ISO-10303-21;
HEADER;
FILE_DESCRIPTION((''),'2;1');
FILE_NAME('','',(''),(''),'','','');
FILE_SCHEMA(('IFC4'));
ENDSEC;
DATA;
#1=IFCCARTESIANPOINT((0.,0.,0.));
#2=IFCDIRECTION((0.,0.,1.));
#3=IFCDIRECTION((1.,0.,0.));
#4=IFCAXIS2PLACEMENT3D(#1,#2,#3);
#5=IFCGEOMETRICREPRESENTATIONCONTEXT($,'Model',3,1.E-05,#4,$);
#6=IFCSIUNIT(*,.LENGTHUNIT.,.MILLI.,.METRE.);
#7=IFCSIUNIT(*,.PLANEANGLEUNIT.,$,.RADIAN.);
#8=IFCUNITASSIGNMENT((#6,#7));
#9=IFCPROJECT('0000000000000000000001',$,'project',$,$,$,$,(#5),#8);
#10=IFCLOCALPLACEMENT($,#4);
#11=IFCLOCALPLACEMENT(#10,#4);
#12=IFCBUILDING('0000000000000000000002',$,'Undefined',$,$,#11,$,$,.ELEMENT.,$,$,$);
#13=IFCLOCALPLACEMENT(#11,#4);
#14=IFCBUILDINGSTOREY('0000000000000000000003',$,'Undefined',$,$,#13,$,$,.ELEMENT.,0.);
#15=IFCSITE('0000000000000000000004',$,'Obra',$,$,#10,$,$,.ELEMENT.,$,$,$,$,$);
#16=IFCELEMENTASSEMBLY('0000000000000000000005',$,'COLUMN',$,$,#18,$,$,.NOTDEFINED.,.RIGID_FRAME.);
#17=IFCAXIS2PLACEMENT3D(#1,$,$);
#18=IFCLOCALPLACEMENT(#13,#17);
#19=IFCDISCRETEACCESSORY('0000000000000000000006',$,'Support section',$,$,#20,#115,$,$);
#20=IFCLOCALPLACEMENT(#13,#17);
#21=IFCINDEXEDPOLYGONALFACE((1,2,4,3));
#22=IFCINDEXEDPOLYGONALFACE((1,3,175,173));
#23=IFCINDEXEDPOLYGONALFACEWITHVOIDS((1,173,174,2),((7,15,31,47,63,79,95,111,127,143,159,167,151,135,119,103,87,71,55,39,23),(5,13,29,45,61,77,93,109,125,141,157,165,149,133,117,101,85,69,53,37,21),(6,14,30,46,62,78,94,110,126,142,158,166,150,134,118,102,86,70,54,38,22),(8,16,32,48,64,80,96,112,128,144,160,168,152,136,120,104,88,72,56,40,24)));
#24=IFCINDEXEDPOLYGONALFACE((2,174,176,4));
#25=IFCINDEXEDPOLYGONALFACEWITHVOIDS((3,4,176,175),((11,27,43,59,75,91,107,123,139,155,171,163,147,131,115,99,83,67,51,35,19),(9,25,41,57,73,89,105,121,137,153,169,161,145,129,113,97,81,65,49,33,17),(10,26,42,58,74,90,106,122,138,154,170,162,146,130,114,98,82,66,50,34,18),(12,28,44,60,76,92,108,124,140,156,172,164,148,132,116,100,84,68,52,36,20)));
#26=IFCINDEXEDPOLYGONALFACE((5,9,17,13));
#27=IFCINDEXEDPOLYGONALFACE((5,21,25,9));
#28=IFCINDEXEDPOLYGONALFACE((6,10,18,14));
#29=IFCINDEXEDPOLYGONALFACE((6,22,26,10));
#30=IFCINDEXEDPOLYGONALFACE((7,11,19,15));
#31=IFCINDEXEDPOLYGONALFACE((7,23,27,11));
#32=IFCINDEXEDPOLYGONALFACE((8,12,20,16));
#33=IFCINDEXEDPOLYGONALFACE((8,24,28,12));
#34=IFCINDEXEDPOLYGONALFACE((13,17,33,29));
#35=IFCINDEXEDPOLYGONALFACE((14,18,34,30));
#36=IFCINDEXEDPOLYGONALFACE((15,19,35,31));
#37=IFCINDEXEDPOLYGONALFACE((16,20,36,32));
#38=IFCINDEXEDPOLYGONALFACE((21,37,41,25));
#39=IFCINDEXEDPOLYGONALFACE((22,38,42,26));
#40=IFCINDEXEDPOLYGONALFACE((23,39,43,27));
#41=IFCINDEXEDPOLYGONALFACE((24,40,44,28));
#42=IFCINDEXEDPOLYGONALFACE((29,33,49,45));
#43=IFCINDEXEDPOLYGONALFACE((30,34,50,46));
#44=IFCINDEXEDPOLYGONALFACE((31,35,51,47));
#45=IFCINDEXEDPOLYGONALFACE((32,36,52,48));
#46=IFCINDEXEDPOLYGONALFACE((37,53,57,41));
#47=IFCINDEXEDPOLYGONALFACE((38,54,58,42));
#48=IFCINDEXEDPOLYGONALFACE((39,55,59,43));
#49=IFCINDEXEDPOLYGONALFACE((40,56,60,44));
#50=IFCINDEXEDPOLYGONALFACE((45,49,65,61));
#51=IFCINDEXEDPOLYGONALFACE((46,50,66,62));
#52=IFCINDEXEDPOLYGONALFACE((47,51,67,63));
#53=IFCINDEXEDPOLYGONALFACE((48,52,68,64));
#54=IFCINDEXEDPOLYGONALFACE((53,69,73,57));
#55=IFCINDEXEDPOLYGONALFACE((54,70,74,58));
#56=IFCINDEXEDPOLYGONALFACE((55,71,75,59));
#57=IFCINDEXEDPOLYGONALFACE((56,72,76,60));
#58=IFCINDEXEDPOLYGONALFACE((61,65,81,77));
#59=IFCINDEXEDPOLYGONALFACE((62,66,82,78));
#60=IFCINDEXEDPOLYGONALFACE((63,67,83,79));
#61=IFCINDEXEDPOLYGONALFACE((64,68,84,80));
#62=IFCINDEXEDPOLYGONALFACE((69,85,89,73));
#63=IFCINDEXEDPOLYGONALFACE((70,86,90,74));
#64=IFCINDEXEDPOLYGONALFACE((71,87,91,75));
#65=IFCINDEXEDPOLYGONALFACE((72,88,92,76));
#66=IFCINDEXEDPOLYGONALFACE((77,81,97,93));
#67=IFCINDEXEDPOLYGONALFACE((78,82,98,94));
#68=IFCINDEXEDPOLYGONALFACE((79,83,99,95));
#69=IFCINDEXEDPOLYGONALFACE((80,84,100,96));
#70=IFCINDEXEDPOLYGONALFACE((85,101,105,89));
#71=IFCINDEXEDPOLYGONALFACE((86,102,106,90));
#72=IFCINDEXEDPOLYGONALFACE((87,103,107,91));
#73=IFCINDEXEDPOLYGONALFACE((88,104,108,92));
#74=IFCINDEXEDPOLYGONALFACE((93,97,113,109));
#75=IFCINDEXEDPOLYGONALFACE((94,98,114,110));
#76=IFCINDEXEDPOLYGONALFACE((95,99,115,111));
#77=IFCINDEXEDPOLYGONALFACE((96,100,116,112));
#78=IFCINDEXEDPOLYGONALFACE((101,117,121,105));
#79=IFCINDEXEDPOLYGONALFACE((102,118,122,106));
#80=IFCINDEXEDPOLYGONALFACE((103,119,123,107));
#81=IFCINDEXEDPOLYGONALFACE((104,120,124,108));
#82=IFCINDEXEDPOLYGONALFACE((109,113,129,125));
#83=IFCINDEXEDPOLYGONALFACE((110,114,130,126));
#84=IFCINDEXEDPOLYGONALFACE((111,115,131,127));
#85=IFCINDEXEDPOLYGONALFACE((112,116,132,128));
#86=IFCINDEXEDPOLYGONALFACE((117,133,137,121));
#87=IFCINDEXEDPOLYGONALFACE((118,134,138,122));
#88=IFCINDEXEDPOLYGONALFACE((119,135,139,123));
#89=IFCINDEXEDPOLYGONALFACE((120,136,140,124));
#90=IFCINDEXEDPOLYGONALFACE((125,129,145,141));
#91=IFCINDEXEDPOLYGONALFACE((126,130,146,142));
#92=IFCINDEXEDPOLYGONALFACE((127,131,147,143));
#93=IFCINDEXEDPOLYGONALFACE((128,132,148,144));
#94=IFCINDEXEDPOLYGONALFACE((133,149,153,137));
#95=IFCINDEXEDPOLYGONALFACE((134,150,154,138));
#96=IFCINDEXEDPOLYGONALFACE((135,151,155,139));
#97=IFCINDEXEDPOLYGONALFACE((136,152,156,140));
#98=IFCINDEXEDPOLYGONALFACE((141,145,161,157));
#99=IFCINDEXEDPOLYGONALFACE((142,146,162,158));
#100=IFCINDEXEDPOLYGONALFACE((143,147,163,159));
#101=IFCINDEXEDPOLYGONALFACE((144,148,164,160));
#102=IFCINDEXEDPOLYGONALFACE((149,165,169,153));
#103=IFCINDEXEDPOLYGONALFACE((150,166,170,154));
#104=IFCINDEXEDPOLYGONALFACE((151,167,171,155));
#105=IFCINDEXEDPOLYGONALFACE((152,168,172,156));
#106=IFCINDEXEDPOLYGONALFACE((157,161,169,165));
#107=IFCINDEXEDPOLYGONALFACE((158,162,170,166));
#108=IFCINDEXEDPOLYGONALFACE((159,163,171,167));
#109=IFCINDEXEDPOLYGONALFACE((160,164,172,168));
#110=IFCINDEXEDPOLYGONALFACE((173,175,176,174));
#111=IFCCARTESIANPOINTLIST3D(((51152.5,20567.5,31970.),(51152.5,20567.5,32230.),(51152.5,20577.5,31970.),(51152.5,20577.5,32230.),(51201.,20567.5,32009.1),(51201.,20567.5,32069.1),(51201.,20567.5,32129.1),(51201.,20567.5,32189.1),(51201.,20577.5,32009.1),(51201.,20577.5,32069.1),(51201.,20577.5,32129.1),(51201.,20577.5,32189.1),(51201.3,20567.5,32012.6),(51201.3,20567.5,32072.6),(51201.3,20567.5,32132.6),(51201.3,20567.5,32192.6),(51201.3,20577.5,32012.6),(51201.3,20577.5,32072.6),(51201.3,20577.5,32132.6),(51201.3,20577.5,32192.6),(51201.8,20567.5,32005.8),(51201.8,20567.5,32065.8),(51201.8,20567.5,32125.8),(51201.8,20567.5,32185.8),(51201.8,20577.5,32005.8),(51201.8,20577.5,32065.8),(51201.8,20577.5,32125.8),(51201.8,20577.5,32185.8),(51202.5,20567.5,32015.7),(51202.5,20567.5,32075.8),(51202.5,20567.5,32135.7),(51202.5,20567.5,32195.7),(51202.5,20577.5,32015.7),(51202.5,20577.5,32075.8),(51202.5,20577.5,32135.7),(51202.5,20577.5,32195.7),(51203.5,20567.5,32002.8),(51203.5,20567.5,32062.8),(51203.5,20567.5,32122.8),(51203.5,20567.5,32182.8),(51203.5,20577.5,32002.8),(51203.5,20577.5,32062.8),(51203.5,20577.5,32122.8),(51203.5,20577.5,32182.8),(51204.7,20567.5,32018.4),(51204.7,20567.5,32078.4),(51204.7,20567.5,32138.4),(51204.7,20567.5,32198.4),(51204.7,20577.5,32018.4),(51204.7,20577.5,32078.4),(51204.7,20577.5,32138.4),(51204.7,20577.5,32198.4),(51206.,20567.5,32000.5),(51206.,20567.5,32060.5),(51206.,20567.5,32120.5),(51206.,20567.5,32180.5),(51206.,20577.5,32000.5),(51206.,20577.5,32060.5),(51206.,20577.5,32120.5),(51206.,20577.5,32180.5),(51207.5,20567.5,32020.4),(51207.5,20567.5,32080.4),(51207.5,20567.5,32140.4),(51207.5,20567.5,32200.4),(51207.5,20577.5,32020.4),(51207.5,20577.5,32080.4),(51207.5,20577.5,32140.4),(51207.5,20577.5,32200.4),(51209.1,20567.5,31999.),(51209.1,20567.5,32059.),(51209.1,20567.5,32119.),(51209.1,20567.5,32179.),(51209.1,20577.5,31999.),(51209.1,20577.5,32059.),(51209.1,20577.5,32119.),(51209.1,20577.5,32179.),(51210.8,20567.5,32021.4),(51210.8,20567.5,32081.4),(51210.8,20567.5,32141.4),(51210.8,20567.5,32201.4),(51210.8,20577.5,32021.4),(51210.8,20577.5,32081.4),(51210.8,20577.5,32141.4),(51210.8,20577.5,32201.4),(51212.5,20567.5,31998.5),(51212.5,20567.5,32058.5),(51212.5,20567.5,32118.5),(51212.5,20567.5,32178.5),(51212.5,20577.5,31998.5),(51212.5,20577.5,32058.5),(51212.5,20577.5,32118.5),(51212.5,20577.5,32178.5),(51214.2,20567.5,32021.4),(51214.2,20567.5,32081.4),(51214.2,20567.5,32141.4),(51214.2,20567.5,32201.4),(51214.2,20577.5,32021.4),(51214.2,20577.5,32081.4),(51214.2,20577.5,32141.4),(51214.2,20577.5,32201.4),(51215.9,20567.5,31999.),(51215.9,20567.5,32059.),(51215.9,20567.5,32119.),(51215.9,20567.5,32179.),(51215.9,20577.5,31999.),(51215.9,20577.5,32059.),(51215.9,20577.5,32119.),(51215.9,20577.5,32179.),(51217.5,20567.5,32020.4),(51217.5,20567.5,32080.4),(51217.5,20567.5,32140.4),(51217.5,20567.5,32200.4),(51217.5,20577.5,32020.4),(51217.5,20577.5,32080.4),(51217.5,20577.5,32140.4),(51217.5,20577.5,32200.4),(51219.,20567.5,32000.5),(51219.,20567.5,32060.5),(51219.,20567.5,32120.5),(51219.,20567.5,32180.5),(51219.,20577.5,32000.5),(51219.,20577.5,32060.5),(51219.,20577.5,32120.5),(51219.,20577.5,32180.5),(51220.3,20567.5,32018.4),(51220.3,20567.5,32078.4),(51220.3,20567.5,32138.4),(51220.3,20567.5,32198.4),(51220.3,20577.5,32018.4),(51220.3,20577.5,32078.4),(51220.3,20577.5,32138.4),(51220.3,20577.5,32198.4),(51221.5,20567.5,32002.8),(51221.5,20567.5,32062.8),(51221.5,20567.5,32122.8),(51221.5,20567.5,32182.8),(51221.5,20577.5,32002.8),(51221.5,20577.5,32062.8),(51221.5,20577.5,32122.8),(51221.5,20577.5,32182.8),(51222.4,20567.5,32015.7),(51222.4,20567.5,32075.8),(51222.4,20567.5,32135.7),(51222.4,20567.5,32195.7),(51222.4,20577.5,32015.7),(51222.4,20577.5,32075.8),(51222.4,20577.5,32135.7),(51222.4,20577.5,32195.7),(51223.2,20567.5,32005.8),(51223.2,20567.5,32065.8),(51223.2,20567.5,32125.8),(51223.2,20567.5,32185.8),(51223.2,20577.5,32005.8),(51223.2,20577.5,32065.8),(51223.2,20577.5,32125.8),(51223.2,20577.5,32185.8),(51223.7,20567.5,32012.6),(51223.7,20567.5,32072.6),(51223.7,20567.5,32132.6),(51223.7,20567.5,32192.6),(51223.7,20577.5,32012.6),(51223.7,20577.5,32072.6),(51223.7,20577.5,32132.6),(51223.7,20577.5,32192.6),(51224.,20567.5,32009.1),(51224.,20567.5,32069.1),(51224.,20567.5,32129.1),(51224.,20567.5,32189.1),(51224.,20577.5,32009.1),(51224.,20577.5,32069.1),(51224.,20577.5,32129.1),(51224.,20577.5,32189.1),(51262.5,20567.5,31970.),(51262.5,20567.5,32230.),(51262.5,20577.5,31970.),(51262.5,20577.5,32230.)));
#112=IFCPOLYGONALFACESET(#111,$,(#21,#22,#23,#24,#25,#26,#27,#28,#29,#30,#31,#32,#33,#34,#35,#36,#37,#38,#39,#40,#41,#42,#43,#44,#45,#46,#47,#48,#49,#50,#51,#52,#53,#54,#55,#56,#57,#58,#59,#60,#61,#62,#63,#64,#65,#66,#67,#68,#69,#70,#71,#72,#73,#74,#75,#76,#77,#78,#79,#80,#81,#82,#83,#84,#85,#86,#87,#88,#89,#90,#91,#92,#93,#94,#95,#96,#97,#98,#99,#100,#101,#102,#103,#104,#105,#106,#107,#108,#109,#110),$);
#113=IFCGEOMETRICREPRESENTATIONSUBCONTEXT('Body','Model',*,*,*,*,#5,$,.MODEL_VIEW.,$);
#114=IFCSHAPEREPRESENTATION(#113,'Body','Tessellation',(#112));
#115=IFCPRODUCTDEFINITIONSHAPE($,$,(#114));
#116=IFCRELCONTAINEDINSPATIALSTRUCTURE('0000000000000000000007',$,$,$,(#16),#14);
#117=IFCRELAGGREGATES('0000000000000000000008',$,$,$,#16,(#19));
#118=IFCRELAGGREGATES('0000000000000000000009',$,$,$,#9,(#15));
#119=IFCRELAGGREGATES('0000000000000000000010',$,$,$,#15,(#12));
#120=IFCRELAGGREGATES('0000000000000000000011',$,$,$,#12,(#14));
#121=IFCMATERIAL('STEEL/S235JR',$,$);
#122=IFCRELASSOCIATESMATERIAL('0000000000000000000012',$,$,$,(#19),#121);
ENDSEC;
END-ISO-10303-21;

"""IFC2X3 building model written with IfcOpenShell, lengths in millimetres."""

from ifc_helpers import new_model, si_unit, frame, origin_with_axes, origin_2d_with_axis, place, context, subcontext, project, spatial, rectangle, circle, extrude, source, transform, mapped, material, element, aggregate, save


model = new_model("IFC2X3")

# Units and contexts
model_context = context("Model", 3, precision=1e-05, world=origin_with_axes())
body_context = subcontext(model_context, "Body", "Model", "MODEL_VIEW")
ifc_project = project(units=[si_unit("LENGTHUNIT", "METRE", prefix="MILLI"), si_unit("PLANEANGLEUNIT", "RADIAN")], contexts=[model_context])

# Site, building, storey
site_placement = place(None, origin_with_axes())
site = spatial("IfcSite", under=ifc_project, at=site_placement, Name="Obra", CompositionType="ELEMENT")
building_placement = place(site_placement, origin_with_axes())
building = spatial("IfcBuilding", under=site, at=building_placement, Name="Undefined", CompositionType="ELEMENT")
storey_placement = place(building_placement, origin_with_axes())
storey = spatial("IfcBuildingStorey", under=building, at=storey_placement, Name="Undefined", CompositionType="ELEMENT", Elevation=0.0)

# Element assembly
ifc_material_1 = material(Name="STEEL/S235JR")
assembly_1_placement = place(storey_placement, origin_with_axes())
assembly_1 = element("IfcElementAssembly", 1, at=assembly_1_placement, inside=storey, Name="COLUMN", AssemblyPlace="NOTDEFINED", PredefinedType="RIGID_FRAME")

# Discrete accessory, opening
discrete_accessory_1_placement = place(assembly_1_placement, frame((51207.5, 20572.5, 31970.0), z_axis=(0.0, 0.0, 1.0), x_axis=(-1.0, 0.0, 0.0)))
discrete_accessory_1 = element("IfcDiscreteAccessory", 2, at=discrete_accessory_1_placement, material=ifc_material_1, Name="Support section", context=body_context, shape_type="SweptSolid", body=[
    extrude(rectangle(XDim=10.0, YDim=110.0, at=origin_2d_with_axis()), frame((0.0, 0.0, 260.0), z_axis=(0.0, 0.0, -1.0), x_axis=(0.0, 1.0, 0.0)), (0.0, 0.0, 1.0), 260.0),
])
shared_shape_1 = source(origin_with_axes(), body_context, "Body", "SweptSolid", [
    extrude(circle(Radius=11.5, at=origin_2d_with_axis()), frame((0.0, -14.4, 0.0), z_axis=(0.0, 1.0, 0.0), x_axis=(1.0, 0.0, 0.0)), (0.0, 0.0, 1.0), 10.2),
])
opening_1_placement = place(assembly_1_placement, frame((51162.5, 20581.8, 32300.0), z_axis=(1.0, 0.0, 0.0), x_axis=(0.0, 0.0, -1.0)))
element("IfcOpeningElement", 3, at=opening_1_placement, cuts=discrete_accessory_1, ObjectType="Opening", context=body_context, shape_type="MappedRepresentation", body=[
    mapped(shared_shape_1, transform((110.0, 0.0, 50.0))),
    mapped(shared_shape_1, transform((170.0, 0.0, 50.0))),
    mapped(shared_shape_1, transform((230.0, 0.0, 50.0))),
    mapped(shared_shape_1, transform((290.0, 0.0, 50.0))),
])
aggregate(assembly_1, [discrete_accessory_1])

save(model, "model.ifc")
